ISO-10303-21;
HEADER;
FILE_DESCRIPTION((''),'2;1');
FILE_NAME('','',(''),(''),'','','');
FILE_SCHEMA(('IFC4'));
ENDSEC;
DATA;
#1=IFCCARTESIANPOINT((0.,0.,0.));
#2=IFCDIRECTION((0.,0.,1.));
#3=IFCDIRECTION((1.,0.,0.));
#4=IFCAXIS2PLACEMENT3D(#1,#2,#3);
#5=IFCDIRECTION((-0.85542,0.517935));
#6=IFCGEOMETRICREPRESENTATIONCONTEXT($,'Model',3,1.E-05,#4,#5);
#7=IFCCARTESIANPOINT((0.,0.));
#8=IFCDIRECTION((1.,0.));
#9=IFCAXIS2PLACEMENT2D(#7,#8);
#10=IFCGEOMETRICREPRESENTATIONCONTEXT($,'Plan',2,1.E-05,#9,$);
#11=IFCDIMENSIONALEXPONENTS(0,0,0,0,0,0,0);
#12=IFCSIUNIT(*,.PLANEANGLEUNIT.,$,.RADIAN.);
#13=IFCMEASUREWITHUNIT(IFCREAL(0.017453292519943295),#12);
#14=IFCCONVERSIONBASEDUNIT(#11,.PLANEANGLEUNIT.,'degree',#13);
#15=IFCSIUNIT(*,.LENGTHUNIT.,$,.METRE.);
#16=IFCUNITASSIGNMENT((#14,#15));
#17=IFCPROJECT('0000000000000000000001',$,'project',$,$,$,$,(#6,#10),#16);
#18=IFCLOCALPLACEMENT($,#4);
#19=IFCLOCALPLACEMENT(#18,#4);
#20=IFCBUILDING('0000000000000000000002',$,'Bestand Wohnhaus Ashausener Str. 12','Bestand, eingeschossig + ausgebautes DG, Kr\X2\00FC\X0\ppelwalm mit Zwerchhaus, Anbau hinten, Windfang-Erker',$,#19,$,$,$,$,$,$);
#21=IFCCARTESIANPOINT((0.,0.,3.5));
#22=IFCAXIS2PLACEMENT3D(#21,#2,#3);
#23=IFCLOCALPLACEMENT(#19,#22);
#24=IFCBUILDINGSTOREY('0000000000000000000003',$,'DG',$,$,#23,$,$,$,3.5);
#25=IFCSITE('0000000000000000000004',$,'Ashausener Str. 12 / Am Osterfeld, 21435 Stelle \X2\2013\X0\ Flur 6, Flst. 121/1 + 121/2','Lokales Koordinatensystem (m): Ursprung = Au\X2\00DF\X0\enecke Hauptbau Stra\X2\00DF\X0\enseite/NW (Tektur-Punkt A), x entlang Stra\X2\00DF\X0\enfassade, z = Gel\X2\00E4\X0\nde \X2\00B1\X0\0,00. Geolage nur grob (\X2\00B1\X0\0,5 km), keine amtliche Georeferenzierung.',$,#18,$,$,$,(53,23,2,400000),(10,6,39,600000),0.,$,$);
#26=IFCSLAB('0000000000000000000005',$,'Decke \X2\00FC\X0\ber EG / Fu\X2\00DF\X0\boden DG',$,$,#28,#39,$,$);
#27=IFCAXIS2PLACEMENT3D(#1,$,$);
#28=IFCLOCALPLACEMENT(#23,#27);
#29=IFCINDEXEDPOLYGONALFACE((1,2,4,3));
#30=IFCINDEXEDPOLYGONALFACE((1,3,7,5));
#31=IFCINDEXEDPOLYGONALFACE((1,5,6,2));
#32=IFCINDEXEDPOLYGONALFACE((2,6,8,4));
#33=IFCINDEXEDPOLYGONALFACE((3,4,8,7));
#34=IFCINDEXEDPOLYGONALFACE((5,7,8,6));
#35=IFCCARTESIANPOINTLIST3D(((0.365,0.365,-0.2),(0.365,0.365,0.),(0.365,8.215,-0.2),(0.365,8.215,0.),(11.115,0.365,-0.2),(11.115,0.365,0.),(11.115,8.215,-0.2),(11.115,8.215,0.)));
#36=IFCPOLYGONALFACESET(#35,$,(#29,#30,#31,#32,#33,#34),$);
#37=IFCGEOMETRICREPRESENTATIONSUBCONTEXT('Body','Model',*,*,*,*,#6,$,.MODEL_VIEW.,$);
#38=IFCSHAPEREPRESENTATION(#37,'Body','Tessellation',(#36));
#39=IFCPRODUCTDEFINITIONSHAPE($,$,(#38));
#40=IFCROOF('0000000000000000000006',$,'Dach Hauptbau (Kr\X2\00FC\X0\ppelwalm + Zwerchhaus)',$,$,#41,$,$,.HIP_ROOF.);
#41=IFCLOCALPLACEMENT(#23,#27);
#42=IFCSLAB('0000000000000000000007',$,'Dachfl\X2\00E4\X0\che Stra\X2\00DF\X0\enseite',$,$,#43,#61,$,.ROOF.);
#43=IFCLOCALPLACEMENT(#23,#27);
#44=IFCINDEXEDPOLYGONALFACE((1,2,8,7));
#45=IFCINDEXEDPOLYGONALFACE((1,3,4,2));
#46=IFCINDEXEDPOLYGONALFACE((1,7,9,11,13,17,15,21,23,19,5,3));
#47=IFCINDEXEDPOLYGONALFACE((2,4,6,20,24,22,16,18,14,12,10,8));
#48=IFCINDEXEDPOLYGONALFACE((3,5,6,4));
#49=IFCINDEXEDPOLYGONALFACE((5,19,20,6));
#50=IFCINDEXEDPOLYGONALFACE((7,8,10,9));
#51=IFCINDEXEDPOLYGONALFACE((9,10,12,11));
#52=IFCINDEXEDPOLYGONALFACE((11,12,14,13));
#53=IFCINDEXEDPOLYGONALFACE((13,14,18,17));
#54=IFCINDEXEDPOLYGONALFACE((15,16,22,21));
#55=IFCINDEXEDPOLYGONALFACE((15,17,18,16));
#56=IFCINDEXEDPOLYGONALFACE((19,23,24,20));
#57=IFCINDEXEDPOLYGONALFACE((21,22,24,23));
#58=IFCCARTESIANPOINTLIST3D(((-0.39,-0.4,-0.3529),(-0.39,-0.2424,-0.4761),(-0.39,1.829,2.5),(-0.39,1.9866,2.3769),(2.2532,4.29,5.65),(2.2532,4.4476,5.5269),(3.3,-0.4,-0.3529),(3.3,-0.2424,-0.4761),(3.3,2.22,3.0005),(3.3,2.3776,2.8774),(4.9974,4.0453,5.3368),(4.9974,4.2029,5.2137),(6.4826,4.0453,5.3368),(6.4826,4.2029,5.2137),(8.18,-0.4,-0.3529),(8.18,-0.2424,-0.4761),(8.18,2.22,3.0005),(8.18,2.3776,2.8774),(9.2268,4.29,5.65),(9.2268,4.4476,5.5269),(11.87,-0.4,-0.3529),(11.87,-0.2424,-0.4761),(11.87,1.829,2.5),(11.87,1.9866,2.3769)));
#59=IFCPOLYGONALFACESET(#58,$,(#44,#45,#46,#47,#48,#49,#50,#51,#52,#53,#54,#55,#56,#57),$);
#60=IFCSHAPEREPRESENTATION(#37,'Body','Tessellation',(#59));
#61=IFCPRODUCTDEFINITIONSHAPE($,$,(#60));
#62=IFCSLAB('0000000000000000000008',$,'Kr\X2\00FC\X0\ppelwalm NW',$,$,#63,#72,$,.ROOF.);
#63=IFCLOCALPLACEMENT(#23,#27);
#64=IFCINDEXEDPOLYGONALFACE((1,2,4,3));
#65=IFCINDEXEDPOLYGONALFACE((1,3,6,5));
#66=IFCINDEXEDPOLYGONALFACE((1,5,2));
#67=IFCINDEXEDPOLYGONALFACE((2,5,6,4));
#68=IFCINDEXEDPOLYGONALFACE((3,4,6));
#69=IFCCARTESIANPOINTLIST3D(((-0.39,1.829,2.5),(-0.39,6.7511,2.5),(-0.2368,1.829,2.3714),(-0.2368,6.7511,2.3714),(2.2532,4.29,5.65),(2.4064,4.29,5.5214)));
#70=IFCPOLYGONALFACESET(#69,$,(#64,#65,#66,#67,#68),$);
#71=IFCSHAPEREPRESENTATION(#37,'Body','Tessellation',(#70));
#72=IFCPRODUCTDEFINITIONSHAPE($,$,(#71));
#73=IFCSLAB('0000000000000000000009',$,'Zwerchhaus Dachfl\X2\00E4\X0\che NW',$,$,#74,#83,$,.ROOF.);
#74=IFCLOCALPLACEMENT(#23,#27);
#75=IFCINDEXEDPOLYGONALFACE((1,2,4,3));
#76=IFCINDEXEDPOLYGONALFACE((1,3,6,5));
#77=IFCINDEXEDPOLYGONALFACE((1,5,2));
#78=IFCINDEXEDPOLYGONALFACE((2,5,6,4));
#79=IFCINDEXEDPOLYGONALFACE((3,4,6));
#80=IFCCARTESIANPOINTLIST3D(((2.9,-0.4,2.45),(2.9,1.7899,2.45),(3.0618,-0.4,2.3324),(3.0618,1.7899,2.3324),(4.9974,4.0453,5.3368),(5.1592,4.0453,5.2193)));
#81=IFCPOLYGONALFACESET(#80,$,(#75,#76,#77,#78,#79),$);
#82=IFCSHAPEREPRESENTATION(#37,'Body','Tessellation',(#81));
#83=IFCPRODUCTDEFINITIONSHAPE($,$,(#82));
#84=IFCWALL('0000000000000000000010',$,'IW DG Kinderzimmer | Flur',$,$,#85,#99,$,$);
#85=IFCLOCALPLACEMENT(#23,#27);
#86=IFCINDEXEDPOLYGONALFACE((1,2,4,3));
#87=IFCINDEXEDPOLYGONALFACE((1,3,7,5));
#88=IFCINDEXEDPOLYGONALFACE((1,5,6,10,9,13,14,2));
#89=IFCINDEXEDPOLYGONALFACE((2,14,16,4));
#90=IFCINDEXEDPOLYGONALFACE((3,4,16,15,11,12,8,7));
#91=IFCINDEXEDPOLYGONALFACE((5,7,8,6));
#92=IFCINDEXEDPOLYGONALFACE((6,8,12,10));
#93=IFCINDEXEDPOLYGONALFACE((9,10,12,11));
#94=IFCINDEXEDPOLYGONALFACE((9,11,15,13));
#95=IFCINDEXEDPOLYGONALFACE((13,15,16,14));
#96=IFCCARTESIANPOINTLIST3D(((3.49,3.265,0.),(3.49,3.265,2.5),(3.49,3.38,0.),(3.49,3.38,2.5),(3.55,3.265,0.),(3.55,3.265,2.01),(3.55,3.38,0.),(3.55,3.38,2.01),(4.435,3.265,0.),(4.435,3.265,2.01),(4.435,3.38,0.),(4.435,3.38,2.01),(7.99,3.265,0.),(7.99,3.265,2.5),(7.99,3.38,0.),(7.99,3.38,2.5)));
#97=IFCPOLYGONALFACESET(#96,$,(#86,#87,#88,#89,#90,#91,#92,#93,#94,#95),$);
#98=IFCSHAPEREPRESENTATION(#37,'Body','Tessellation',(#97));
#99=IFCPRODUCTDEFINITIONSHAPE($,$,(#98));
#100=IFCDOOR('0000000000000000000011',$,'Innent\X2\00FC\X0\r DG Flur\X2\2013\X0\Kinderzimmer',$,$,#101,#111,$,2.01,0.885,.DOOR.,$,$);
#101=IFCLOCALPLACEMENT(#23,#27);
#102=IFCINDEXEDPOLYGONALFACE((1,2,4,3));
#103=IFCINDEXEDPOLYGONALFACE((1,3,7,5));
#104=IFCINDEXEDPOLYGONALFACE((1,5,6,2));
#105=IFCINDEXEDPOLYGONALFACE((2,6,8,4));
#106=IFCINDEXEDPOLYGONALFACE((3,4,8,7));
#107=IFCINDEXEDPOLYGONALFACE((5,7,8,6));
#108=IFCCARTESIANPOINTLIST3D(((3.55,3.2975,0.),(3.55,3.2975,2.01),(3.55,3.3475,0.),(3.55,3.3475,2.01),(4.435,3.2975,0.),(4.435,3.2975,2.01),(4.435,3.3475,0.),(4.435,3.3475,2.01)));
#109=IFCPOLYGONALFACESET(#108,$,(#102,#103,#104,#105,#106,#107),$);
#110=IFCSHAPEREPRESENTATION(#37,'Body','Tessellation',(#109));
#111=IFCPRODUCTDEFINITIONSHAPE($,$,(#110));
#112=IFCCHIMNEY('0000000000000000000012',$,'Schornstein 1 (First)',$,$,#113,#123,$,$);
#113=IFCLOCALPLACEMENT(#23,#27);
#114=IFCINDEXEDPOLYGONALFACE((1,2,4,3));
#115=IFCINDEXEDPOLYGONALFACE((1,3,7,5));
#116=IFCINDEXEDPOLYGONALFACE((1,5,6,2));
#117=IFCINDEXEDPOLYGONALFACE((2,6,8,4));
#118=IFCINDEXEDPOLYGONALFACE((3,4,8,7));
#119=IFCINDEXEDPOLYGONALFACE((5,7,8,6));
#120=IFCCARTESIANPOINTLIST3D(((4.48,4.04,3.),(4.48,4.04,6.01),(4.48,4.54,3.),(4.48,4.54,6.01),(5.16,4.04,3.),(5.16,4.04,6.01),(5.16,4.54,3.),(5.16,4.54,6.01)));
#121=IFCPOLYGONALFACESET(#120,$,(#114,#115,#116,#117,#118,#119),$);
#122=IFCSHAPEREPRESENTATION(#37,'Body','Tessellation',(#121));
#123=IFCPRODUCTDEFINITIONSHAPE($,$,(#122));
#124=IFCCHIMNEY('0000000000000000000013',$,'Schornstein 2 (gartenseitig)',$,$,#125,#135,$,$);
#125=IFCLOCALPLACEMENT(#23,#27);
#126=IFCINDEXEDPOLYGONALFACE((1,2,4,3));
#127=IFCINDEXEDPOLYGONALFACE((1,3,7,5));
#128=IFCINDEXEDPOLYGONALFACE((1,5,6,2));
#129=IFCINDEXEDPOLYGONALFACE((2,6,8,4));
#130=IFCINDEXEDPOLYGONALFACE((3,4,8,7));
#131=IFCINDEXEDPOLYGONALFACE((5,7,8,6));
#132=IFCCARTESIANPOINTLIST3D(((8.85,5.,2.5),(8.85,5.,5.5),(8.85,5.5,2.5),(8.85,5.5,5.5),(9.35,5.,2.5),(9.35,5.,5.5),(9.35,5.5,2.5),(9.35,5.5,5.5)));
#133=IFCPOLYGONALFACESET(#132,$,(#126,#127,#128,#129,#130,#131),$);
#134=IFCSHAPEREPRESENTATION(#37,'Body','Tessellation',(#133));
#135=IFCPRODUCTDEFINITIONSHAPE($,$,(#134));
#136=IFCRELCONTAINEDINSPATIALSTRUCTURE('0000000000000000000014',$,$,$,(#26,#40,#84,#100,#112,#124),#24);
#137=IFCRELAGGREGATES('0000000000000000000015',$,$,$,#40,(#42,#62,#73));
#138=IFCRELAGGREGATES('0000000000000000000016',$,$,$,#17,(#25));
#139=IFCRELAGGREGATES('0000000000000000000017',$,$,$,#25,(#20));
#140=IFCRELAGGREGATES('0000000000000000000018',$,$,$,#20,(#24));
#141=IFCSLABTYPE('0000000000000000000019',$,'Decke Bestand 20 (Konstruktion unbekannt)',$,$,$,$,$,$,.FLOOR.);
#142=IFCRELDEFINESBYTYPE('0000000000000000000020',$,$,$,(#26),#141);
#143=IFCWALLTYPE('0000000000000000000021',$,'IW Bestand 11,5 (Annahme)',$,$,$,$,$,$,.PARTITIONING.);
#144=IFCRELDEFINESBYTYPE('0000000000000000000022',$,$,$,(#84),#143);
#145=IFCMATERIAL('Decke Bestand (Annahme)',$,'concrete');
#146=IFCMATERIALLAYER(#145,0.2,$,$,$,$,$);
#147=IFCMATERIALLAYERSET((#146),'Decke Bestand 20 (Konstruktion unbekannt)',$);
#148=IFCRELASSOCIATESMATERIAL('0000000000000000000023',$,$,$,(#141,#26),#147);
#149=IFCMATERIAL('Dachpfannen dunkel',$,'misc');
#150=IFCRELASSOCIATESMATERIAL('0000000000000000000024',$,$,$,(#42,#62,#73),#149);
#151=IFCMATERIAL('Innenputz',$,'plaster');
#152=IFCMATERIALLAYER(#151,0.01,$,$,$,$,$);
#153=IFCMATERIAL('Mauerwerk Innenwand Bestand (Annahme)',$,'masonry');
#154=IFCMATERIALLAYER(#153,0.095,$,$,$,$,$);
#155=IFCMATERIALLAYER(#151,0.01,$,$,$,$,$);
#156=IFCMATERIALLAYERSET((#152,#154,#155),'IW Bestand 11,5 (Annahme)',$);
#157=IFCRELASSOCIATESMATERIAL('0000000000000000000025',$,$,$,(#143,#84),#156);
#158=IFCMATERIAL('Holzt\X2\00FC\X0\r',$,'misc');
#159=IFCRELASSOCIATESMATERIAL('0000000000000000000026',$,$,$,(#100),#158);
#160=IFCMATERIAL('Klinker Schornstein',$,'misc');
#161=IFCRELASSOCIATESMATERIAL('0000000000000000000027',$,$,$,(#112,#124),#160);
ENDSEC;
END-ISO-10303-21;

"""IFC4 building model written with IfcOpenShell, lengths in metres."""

from ifc_helpers import new_model, entity, si_unit, converted_unit, direction, frame, origin_with_axes, origin_2d_with_axis, place, context, subcontext, project, spatial, polyline, indexed_curve, outline, extrude, material, layer, layer_set, layer_usage, type_object, element, fill, aggregate, save


model = new_model("IFC4")

# Units and contexts
model_context = context("Model", 3, precision=1e-05, world=origin_with_axes(), true_north=direction((-0.85542, 0.517935)))
plan_context = context("Plan", 2, precision=1e-05, world=origin_2d_with_axis())
body_context = subcontext(model_context, "Body", "Model", "MODEL_VIEW")
ifc_project = project(units=[converted_unit("PLANEANGLEUNIT", "degree", entity("IfcReal", 0.017453292519943295), si_unit("PLANEANGLEUNIT", "RADIAN"), dimensions=[0, 0, 0, 0, 0, 0, 0]), si_unit("LENGTHUNIT", "METRE")], contexts=[model_context, plan_context])

# Site, building, storey
site_placement = place(None, origin_with_axes())
site = spatial("IfcSite", under=ifc_project, at=site_placement, Name="Ashausener Str. 12 / Am Osterfeld, 21435 Stelle – Flur 6, Flst. 121/1 + 121/2", Description="Lokales Koordinatensystem (m): Ursprung = Außenecke Hauptbau Straßenseite/NW (Tektur-Punkt A), x entlang Straßenfassade, z = Gelände ±0,00. Geolage nur grob (±0,5 km), keine amtliche Georeferenzierung.", RefLatitude=(53, 23, 2, 400000), RefLongitude=(10, 6, 39, 600000), RefElevation=0.0)
building_placement = place(site_placement, origin_with_axes())
building = spatial("IfcBuilding", under=site, at=building_placement, Name="Bestand Wohnhaus Ashausener Str. 12", Description="Bestand, eingeschossig + ausgebautes DG, Krüppelwalm mit Zwerchhaus, Anbau hinten, Windfang-Erker")
storey_placement = place(building_placement, frame((0.0, 0.0, 3.5), z_axis=(0.0, 0.0, 1.0), x_axis=(1.0, 0.0, 0.0)))
storey = spatial("IfcBuildingStorey", under=building, at=storey_placement, Name="DG", Elevation=3.5)

# Slab
ifc_material_1 = material(Name="Decke Bestand (Annahme)", Category="concrete")
ifc_layer_1 = layer(ifc_material_1, 0.2)
ifc_layer_set_1 = layer_set([ifc_layer_1], Name="Decke Bestand 20 (Konstruktion unbekannt)")
ifc_layer_usage_1 = layer_usage(ifc_layer_set_1, "AXIS3", "POSITIVE", 0.0)
slab_type = type_object("IfcSlabType", Name="Decke Bestand 20 (Konstruktion unbekannt)", PredefinedType="FLOOR", material=ifc_layer_set_1)
slab_1_placement = place(storey_placement, frame((0.0, 0.0, -3.5), z_axis=(0.0, 0.0, 1.0), x_axis=(1.0, 0.0, 0.0)))
element("IfcSlab", 1, at=slab_1_placement, inside=storey, type_object=slab_type, material=ifc_layer_usage_1, Name="Decke über EG / Fußboden DG", context=body_context, shape_type="SweptSolid", body=[
    extrude(outline(polyline([(0.365, 0.365), (11.115, 0.365), (11.115, 8.215), (0.365, 8.215), (0.365, 0.365)])), frame((0.0, 0.0, 3.3)), (0.0, 0.0, 1.0), 0.2),
])

# Roof, slabs
roof_placement = place(storey_placement, frame((0.0, 0.0, -3.5), z_axis=(0.0, 0.0, 1.0), x_axis=(1.0, 0.0, 0.0)))
roof = element("IfcRoof", 2, at=roof_placement, inside=storey, Name="Dach Hauptbau (Krüppelwalm + Zwerchhaus)", PredefinedType="HIP_ROOF")
ifc_material_2 = material(Name="Dachpfannen dunkel", Category="misc")
slab_2_placement = place(roof_placement, origin_with_axes())
slab_2 = element("IfcSlab", 3, at=slab_2_placement, material=ifc_material_2, Name="Dachfläche Straßenseite", PredefinedType="ROOF", context=body_context, shape_type="SweptSolid", body=[
    extrude(outline(polyline([(0.0, 0.0), (3.69, 0.0), (3.69, 4.2556), (5.3874, 7.2204), (6.8726, 7.2204), (8.57, 4.2556), (8.57, 0.0), (12.26, 0.0), (12.26, 3.6204), (9.6168, 7.6178), (2.6432, 7.6178), (0.0, 3.6204), (0.0, 0.0)])), frame((-0.39, -0.4, 3.1471), z_axis=(0.0, -0.788011, 0.615661), x_axis=(1.0, 0.0, 0.0)), (0.0, 0.0, -1.0), 0.2),
])
slab_3_placement = place(roof_placement, origin_with_axes())
slab_3 = element("IfcSlab", 4, at=slab_3_placement, material=ifc_material_2, Name="Krüppelwalm NW", PredefinedType="ROOF", context=body_context, shape_type="SweptSolid", body=[
    extrude(outline(polyline([(0.0, 0.0), (4.7922, 0.0), (2.5277, 4.2235), (0.0, 0.0)])), frame((-0.39, 1.829, 6.0), z_axis=(-0.766045, 0.0, 0.642787), x_axis=(0.55155, 0.513549, 0.657313)), (0.0, 0.0, -1.0), 0.2),
])
slab_4_placement = place(roof_placement, origin_with_axes())
slab_4 = element("IfcSlab", 5, at=slab_4_placement, material=ifc_material_2, Name="Zwerchhaus Dachfläche NW", PredefinedType="ROOF", context=body_context, shape_type="SweptSolid", body=[
    extrude(outline(polyline([(0.0, 0.0), (5.7003, 0.0), (1.7078, 1.3708), (0.0, 0.0)])), frame((2.9, -0.4, 5.95), z_axis=(-0.809018, 0.0, 0.587784), x_axis=(0.367944, 0.779836, 0.506432)), (0.0, 0.0, -1.0), 0.2),
])
aggregate(roof, [slab_2, slab_3, slab_4])

# Wall, opening, door
ifc_material_3 = material(Name="Innenputz", Category="plaster")
ifc_layer_2 = layer(ifc_material_3, 0.01)
ifc_material_4 = material(Name="Mauerwerk Innenwand Bestand (Annahme)", Category="masonry")
ifc_layer_3 = layer(ifc_material_4, 0.095)
ifc_layer_4 = layer(ifc_material_3, 0.01)
ifc_layer_set_2 = layer_set([ifc_layer_2, ifc_layer_3, ifc_layer_4], Name="IW Bestand 11,5 (Annahme)")
ifc_layer_usage_2 = layer_usage(ifc_layer_set_2, "AXIS2", "POSITIVE", 0.0)
wall_type_1 = type_object("IfcWallType", Name="IW Bestand 11,5 (Annahme)", PredefinedType="PARTITIONING", material=ifc_layer_set_2)
wall_1_placement = place(storey_placement, frame((3.49, 3.265, 0.0), z_axis=(0.0, 0.0, 1.0), x_axis=(1.0, 0.0, 0.0)))
wall_1 = element("IfcWall", 6, at=wall_1_placement, inside=storey, type_object=wall_type_1, material=ifc_layer_usage_2, Name="IW DG Kinderzimmer | Flur", context=body_context, shape_type="SweptSolid", body=[
    extrude(outline(indexed_curve([(0.0, 0.0), (0.0, 0.115), (4.5, 0.115), (4.5, 0.0), (0.0, 0.0)], self_intersect=False)), origin_with_axes(), (0.0, 0.0, 1.0), 2.5),
])
opening_1_placement = place(wall_1_placement, frame((0.06, -0.1, 0.0), z_axis=(0.0, 0.0, 1.0), x_axis=(1.0, 0.0, 0.0)))
opening_1 = element("IfcOpeningElement", 7, at=opening_1_placement, cuts=wall_1, context=body_context, shape_type="SweptSolid", body=[
    extrude(outline(indexed_curve([(0.0, 0.0), (0.0, 0.315), (0.885, 0.315), (0.885, 0.0), (0.0, 0.0)], self_intersect=False)), origin_with_axes(), (0.0, 0.0, 1.0), 2.01),
])
ifc_material_5 = material(Name="Holztür", Category="misc")
door_1_placement = place(storey_placement, frame((3.55, 3.2975, 0.0), z_axis=(0.0, 0.0, 1.0), x_axis=(1.0, 0.0, 0.0)))
door_1 = element("IfcDoor", 8, at=door_1_placement, inside=storey, material=ifc_material_5, Name="Innentür DG Flur–Kinderzimmer", OverallHeight=2.01, OverallWidth=0.885, PredefinedType="DOOR", context=body_context, shape_type="SweptSolid", body=[
    extrude(outline(indexed_curve([(0.0, 0.0), (0.0, 0.05), (0.885, 0.05), (0.885, 0.0), (0.0, 0.0)], self_intersect=False)), origin_with_axes(), (0.0, 0.0, 1.0), 2.01),
])
fill(opening_1, door_1)

# Chimneys
ifc_material_6 = material(Name="Klinker Schornstein", Category="misc")
chimney_1_placement = place(storey_placement, frame((0.0, 0.0, -3.5), z_axis=(0.0, 0.0, 1.0), x_axis=(1.0, 0.0, 0.0)))
element("IfcChimney", 9, at=chimney_1_placement, inside=storey, material=ifc_material_6, Name="Schornstein 1 (First)", context=body_context, shape_type="SweptSolid", body=[
    extrude(outline(polyline([(4.48, 4.04), (5.16, 4.04), (5.16, 4.54), (4.48, 4.54), (4.48, 4.04)])), frame((0.0, 0.0, 6.5)), (0.0, 0.0, 1.0), 3.01),
])
chimney_2_placement = place(storey_placement, frame((0.0, 0.0, -3.5), z_axis=(0.0, 0.0, 1.0), x_axis=(1.0, 0.0, 0.0)))
element("IfcChimney", 10, at=chimney_2_placement, inside=storey, material=ifc_material_6, Name="Schornstein 2 (gartenseitig)", context=body_context, shape_type="SweptSolid", body=[
    extrude(outline(polyline([(8.85, 5.0), (9.35, 5.0), (9.35, 5.5), (8.85, 5.5), (8.85, 5.0)])), frame((0.0, 0.0, 6.0)), (0.0, 0.0, 1.0), 3.0),
])

save(model, "model.ifc")
